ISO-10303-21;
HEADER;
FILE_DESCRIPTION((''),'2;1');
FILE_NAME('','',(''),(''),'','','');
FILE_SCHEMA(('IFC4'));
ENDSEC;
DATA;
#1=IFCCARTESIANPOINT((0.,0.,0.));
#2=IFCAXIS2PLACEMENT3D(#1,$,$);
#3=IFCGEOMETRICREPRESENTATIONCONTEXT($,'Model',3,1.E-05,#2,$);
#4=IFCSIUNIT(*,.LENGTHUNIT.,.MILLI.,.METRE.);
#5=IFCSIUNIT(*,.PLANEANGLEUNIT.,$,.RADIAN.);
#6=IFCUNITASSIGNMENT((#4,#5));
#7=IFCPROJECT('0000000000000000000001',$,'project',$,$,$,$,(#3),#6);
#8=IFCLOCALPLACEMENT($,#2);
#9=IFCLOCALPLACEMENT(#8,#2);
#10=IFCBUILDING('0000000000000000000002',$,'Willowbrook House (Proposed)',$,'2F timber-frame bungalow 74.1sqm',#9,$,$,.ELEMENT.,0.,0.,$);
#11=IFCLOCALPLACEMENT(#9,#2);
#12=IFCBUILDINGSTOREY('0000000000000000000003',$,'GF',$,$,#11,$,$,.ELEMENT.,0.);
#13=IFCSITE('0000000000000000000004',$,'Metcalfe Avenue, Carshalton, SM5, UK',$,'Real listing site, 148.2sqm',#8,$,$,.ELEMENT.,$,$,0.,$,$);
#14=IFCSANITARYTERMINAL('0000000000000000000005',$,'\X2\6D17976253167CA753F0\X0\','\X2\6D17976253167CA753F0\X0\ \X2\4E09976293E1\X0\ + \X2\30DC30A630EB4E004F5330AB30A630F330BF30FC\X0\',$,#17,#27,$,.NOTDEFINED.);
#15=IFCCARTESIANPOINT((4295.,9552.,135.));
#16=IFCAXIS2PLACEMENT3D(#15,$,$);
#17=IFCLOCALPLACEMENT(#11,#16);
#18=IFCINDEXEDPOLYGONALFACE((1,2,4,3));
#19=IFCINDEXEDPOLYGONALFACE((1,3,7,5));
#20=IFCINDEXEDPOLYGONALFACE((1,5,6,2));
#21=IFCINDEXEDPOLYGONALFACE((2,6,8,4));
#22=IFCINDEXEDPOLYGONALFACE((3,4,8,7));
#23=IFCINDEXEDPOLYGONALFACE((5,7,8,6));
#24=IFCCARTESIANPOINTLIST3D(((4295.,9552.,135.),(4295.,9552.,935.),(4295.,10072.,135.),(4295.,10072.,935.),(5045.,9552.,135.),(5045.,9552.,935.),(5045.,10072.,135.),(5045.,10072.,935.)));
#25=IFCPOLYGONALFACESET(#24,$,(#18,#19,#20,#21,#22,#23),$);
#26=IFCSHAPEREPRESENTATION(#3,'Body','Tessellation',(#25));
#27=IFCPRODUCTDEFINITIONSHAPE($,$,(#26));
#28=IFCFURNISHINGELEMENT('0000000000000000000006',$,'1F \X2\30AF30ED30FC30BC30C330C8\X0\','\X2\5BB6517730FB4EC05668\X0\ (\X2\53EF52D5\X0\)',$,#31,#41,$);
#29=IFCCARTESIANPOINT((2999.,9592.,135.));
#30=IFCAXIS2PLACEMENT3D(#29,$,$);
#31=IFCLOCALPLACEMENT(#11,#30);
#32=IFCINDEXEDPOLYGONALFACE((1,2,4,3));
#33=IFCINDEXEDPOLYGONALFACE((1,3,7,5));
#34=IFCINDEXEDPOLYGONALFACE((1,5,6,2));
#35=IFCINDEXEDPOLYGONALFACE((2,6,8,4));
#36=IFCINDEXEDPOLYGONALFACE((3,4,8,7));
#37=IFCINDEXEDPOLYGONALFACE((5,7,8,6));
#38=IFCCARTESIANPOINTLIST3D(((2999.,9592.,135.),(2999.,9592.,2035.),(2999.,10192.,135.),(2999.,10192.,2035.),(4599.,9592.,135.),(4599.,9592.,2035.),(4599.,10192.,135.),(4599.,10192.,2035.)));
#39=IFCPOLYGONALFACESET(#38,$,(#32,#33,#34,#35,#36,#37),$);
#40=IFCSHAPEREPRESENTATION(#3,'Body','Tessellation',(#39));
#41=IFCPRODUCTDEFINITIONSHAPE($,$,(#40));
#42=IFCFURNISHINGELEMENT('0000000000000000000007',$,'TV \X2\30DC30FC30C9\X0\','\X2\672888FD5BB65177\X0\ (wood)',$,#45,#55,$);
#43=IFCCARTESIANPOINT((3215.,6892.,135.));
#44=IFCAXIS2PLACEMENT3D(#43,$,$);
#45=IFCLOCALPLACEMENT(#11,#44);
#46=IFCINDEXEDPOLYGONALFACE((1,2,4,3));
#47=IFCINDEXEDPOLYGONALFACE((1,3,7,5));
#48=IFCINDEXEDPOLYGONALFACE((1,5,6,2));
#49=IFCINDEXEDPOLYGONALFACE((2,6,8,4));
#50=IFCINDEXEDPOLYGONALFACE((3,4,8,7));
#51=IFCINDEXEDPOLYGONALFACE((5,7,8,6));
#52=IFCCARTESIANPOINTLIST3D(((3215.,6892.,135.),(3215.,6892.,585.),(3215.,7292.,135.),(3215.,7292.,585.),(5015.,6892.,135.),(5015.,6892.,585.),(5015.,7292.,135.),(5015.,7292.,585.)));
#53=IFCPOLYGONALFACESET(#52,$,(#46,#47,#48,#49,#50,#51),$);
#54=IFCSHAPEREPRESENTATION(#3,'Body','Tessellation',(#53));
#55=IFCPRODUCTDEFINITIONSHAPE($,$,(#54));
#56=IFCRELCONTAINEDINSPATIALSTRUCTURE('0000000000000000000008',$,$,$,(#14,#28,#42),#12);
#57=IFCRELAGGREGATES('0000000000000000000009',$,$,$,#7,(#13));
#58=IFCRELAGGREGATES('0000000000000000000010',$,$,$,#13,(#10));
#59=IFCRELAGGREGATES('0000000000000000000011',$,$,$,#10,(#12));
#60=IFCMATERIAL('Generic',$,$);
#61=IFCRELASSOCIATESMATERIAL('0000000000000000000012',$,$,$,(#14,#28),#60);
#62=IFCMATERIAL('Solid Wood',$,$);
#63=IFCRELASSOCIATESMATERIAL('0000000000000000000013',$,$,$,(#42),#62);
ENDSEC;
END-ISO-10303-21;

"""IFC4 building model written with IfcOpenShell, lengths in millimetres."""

from ifc_helpers import new_model, si_unit, frame, frame_2d, origin, place, context, project, spatial, rectangle, extrude, material, element, save


model = new_model("IFC4")

# Units and contexts
model_context = context("Model", 3, precision=1e-05, world=origin())
ifc_project = project(units=[si_unit("LENGTHUNIT", "METRE", prefix="MILLI"), si_unit("PLANEANGLEUNIT", "RADIAN")], contexts=[model_context])

# Site, building, storey
site_placement = place(None, origin())
site = spatial("IfcSite", under=ifc_project, at=site_placement, Name="Metcalfe Avenue, Carshalton, SM5, UK", ObjectType="Real listing site, 148.2sqm", CompositionType="ELEMENT", RefElevation=0.0)
building_placement = place(site_placement, origin())
building = spatial("IfcBuilding", under=site, at=building_placement, Name="Willowbrook House (Proposed)", ObjectType="2F timber-frame bungalow 74.1sqm", CompositionType="ELEMENT", ElevationOfRefHeight=0.0, ElevationOfTerrain=0.0)
storey_placement = place(building_placement, origin())
storey = spatial("IfcBuildingStorey", under=building, at=storey_placement, Name="GF", CompositionType="ELEMENT", Elevation=0.0)

# Shared definitions
ifc_material_1 = material(Name="Solid Wood")

# Shared definitions
ifc_material_2 = material(Name="Generic")

# Sanitary terminal
sanitary_terminal_1_placement = place(storey_placement, frame((4295.0, 9552.0, 135.0)))
element("IfcSanitaryTerminal", 1, at=sanitary_terminal_1_placement, inside=storey, material=ifc_material_2, Name="洗面化粧台", Description="洗面化粧台 三面鏡 + ボウル一体カウンター", PredefinedType="NOTDEFINED", context=model_context, shape_type="SweptSolid", body=[
    extrude(rectangle(XDim=750.0, YDim=520.0, at=frame_2d((375.0, 260.0))), frame((4295.0, 9552.0, 135.0)), (0.0, 0.0, 1.0), 800.0),
])

# Furnishing elements
furnishing_1_placement = place(storey_placement, frame((2999.0, 9592.0, 135.0)))
element("IfcFurnishingElement", 2, at=furnishing_1_placement, inside=storey, material=ifc_material_2, Name="1F クローゼット", Description="家具・什器 (可動)", context=model_context, shape_type="SweptSolid", body=[
    extrude(rectangle(XDim=1600.0, YDim=600.0, at=frame_2d((800.0, 300.0))), frame((2999.0, 9592.0, 135.0)), (0.0, 0.0, 1.0), 1900.0),
])
furnishing_2_placement = place(storey_placement, frame((3215.0, 6892.0, 135.0)))
element("IfcFurnishingElement", 3, at=furnishing_2_placement, inside=storey, material=ifc_material_1, Name="TV ボード", Description="木製家具 (wood)", context=model_context, shape_type="SweptSolid", body=[
    extrude(rectangle(XDim=1800.0, YDim=400.0, at=frame_2d((900.0, 200.0))), frame((3215.0, 6892.0, 135.0)), (0.0, 0.0, 1.0), 450.0),
])

save(model, "model.ifc")
